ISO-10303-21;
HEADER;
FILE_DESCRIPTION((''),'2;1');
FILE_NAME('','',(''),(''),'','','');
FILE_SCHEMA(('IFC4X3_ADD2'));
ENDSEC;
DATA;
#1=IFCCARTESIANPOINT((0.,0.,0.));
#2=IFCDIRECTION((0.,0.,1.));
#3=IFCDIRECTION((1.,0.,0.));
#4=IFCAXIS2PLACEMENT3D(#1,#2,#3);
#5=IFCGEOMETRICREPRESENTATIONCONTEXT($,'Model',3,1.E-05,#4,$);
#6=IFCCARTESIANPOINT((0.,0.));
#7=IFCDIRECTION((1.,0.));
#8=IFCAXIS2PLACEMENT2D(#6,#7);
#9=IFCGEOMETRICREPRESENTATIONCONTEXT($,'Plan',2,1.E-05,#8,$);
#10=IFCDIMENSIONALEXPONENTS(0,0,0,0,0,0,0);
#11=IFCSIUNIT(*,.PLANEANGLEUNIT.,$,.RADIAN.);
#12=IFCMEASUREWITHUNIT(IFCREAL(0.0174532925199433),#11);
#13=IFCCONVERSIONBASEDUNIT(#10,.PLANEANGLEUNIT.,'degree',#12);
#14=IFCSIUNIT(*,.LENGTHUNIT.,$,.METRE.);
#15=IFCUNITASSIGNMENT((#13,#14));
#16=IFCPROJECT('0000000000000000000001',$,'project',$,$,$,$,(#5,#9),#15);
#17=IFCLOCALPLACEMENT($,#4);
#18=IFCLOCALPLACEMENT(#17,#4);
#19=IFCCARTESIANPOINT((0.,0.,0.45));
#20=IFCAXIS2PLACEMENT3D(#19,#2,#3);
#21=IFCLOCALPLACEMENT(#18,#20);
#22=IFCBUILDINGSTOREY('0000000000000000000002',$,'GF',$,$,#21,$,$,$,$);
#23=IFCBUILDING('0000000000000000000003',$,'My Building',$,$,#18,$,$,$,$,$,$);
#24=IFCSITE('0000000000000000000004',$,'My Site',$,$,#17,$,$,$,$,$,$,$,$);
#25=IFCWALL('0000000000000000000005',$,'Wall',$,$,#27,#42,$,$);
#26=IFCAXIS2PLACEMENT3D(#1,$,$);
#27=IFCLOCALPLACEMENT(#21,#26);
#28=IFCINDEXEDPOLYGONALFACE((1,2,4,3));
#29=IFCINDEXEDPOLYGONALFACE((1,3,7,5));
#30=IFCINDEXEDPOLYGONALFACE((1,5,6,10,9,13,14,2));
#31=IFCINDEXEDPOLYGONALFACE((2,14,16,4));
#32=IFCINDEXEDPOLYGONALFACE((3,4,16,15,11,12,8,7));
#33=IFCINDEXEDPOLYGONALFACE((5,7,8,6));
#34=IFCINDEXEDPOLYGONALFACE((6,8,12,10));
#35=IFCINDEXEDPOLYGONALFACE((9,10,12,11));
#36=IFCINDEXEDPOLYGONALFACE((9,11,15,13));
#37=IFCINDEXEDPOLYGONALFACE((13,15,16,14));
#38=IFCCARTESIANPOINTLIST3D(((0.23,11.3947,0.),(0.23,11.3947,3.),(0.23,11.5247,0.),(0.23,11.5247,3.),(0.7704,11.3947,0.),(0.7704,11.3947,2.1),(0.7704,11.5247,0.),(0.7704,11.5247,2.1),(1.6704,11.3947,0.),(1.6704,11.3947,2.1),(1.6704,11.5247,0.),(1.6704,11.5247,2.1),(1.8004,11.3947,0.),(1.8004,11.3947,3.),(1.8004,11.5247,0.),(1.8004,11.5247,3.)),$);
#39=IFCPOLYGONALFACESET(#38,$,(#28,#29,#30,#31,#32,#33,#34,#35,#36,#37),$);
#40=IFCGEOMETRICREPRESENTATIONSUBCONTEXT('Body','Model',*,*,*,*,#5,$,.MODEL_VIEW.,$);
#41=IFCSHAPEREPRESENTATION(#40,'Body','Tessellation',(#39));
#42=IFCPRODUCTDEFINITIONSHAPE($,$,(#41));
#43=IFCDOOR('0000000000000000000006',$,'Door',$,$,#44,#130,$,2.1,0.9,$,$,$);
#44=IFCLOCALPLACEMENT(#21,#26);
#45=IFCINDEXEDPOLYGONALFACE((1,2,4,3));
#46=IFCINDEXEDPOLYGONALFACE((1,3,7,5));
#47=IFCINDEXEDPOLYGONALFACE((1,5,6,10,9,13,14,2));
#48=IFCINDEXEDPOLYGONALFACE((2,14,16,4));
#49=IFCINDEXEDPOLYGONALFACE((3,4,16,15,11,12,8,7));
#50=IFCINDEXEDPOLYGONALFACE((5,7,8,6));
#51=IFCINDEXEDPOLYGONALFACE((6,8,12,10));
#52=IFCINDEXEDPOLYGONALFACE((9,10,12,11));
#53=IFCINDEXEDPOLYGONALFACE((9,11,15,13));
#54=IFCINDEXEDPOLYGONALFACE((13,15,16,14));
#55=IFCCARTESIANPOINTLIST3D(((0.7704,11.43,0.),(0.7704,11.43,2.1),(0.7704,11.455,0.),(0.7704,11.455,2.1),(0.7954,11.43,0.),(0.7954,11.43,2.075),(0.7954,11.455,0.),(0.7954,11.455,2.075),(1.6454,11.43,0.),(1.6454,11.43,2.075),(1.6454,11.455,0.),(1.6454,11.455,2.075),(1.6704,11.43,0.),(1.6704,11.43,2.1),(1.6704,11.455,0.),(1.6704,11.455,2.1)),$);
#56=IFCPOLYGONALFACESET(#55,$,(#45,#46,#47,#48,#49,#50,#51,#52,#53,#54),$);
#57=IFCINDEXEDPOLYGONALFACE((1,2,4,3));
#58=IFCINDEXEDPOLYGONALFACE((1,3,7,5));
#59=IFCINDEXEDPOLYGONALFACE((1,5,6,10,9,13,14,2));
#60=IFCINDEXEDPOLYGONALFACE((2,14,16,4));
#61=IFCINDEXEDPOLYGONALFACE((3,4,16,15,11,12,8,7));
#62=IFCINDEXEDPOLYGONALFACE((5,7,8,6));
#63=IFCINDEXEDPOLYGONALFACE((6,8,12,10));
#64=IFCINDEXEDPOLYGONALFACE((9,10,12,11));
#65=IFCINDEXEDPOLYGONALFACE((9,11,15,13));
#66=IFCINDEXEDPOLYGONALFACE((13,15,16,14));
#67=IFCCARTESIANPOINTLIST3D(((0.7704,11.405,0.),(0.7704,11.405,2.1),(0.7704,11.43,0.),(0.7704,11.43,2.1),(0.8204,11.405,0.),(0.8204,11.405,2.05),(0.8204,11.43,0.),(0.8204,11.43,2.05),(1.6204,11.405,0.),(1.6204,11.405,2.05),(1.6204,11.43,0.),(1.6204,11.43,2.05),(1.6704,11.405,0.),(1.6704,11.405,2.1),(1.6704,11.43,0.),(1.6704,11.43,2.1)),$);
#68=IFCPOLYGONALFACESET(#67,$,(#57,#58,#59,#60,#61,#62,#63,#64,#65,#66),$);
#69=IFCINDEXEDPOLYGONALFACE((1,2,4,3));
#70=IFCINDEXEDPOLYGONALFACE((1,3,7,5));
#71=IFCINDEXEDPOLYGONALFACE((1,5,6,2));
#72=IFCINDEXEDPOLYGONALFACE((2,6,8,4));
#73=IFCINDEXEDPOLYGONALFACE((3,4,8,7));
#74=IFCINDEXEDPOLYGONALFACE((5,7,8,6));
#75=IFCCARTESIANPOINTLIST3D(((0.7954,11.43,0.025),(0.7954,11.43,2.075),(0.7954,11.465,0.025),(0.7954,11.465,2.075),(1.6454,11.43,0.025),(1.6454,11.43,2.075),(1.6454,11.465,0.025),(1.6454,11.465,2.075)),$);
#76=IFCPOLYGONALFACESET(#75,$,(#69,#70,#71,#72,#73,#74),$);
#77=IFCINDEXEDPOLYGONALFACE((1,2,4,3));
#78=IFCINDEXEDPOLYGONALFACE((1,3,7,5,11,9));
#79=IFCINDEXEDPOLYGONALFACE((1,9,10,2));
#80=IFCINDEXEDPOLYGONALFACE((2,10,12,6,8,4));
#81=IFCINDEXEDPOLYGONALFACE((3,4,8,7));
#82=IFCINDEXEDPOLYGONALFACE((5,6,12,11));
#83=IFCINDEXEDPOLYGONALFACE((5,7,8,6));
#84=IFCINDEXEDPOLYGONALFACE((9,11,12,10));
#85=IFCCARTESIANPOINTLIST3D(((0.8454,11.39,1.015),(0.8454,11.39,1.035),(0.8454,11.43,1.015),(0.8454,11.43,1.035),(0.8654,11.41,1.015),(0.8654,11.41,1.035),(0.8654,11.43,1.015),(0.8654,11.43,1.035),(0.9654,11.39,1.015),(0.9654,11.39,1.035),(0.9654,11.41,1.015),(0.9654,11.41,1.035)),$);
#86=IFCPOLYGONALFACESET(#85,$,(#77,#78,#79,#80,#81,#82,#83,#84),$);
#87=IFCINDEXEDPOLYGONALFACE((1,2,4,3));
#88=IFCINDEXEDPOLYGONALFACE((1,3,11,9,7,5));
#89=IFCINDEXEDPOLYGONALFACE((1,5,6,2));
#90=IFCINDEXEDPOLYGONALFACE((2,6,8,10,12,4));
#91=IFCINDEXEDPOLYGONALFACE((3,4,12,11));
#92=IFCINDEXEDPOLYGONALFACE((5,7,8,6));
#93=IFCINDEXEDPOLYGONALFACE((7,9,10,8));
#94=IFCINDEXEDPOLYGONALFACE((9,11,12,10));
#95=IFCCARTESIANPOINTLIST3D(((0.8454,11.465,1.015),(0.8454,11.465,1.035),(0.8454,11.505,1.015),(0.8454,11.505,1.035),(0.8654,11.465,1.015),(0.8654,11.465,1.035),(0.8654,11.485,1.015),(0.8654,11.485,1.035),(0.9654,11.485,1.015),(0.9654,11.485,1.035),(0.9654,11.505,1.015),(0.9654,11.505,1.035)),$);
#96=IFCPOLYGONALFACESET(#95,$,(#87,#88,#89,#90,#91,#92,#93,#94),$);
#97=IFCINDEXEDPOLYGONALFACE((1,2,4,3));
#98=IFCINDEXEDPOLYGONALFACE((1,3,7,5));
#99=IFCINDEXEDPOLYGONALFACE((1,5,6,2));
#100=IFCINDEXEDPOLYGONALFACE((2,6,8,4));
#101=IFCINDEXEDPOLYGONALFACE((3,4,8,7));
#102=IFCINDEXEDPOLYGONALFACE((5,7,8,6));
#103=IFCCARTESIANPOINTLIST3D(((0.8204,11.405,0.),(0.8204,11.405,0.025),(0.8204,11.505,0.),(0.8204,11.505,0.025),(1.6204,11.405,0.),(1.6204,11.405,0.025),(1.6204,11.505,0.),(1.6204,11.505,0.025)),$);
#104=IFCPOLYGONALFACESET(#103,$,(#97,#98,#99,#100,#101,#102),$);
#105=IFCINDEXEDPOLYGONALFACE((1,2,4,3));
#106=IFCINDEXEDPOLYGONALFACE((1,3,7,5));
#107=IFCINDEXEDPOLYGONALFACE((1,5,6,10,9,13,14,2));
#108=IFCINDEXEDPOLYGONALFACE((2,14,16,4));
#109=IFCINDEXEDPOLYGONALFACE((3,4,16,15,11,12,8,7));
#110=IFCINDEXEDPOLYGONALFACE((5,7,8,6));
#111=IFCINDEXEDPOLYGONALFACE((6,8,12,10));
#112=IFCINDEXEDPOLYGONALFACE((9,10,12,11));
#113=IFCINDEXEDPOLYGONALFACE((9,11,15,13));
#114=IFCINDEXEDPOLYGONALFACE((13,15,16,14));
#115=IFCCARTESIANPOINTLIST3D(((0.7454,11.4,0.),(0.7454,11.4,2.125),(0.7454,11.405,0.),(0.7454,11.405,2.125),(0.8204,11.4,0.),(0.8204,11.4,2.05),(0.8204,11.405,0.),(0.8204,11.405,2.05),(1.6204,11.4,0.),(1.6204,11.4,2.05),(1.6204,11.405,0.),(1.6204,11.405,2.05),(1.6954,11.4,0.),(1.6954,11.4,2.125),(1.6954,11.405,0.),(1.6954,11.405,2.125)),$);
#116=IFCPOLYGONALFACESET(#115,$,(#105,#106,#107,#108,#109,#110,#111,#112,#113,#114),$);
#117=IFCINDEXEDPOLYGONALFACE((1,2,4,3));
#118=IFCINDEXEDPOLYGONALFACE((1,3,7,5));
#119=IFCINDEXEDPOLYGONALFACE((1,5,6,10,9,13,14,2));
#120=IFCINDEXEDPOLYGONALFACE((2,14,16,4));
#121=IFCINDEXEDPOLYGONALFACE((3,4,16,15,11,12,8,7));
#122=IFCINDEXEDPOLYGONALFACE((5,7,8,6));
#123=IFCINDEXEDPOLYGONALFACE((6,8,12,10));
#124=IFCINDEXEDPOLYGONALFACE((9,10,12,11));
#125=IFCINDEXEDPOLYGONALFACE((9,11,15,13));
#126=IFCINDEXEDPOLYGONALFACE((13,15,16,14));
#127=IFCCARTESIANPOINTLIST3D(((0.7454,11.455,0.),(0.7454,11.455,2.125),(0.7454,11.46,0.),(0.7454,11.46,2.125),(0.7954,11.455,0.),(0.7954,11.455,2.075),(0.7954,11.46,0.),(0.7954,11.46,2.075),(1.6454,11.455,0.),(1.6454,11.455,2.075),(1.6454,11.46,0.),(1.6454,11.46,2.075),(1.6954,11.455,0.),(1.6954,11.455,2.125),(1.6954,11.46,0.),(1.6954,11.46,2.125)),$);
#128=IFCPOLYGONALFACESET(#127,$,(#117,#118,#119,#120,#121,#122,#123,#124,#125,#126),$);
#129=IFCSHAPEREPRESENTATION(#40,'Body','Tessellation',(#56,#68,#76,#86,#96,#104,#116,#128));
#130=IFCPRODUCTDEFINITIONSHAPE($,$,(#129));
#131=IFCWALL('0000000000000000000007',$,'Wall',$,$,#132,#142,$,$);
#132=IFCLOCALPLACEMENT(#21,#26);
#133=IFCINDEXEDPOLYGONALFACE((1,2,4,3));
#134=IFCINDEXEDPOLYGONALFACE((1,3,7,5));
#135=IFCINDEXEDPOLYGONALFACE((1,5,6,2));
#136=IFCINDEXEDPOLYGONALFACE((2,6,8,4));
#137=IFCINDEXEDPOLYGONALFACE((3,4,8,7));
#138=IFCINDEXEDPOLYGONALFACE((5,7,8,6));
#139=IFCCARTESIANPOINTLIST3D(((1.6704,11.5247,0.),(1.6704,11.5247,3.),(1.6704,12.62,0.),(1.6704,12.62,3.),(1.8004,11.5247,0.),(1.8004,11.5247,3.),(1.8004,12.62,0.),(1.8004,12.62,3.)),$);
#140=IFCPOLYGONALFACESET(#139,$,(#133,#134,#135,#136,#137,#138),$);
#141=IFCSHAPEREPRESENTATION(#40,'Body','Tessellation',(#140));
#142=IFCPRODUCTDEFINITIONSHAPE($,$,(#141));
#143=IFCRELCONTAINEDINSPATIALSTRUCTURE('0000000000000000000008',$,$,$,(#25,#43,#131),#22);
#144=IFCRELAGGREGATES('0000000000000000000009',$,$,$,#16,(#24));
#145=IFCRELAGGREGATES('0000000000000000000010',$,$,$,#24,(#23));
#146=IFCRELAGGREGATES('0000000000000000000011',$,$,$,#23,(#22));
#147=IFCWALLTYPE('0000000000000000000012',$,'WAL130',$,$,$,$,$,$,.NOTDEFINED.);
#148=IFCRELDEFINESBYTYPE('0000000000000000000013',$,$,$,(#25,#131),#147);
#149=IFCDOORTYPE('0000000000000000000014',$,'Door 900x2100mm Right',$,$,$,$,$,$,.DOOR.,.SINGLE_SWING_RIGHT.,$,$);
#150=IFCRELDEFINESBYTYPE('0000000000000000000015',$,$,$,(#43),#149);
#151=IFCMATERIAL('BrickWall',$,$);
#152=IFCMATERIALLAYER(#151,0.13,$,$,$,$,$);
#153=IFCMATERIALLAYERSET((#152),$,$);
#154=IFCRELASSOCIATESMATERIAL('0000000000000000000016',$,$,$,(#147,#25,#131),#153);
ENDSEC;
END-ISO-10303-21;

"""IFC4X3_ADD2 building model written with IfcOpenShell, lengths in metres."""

from ifc_helpers import new_model, entity, si_unit, converted_unit, frame, origin_with_axes, origin_2d_with_axis, place, context, subcontext, project, spatial, line, indexed_curve, outline, extrude, shape, source, transform, mapped, material, layer, layer_set, layer_usage, type_object, type_shapes, element, fill, save


model = new_model("IFC4X3_ADD2")

# Units and contexts
model_context = context("Model", 3, precision=1e-05, world=origin_with_axes())
plan_context = context("Plan", 2, precision=1e-05, world=origin_2d_with_axis())
body_context_1 = subcontext(model_context, "Body", "Model", "MODEL_VIEW")
body_context_2 = subcontext(plan_context, "Body", "Plan", "PLAN_VIEW")
ifc_project = project(units=[converted_unit("PLANEANGLEUNIT", "degree", entity("IfcReal", 0.0174532925199433), si_unit("PLANEANGLEUNIT", "RADIAN"), dimensions=[0, 0, 0, 0, 0, 0, 0]), si_unit("LENGTHUNIT", "METRE")], contexts=[model_context, plan_context])

# Site, building, storey
site_placement = place(None, origin_with_axes())
site = spatial("IfcSite", under=ifc_project, at=site_placement, Name="My Site")
building_placement = place(site_placement, origin_with_axes())
building = spatial("IfcBuilding", under=site, at=building_placement, Name="My Building")
storey_placement = place(building_placement, frame((0.0, 0.0, 0.45), z_axis=(0.0, 0.0, 1.0), x_axis=(1.0, 0.0, 0.0)))
storey = spatial("IfcBuildingStorey", under=building, at=storey_placement, Name="GF")

# Shared definitions
ifc_material = material(Name="BrickWall")

# Wall, opening, door
ifc_layer_1 = layer(ifc_material, 0.13)
ifc_layer_set_1 = layer_set([ifc_layer_1])
wall_type_1 = type_object("IfcWallType", Name="WAL130", PredefinedType="NOTDEFINED", material=ifc_layer_set_1)
ifc_layer_usage_1 = layer_usage(ifc_layer_set_1, "AXIS2", "POSITIVE", 0.0)
wall_1_placement = place(storey_placement, frame((0.23, 11.3947, 0.0), z_axis=(0.0, 0.0, 1.0), x_axis=(1.0, 0.0, 0.0)))
wall_1 = element("IfcWall", 1, at=wall_1_placement, inside=storey, type_object=wall_type_1, material=ifc_layer_usage_1, Name="Wall", context=body_context_1, shape_type="SweptSolid", body=[
    extrude(outline(indexed_curve([(0.0, 0.0), (0.0, 0.13), (1.5704, 0.13), (1.5704, 0.0), (0.0, 0.0)], self_intersect=False)), origin_with_axes(), (0.0, 0.0, 1.0), 3.0),
])
shared_shape_1 = source(origin_with_axes(), body_context_1, "Body", "SweptSolid", [
    extrude(outline(indexed_curve([(0.0, 0.0), (0.9, 0.0), (0.9, 2.1), (0.0, 2.1)], segments=[line(1, 2, 3, 4, 1)])), frame((0.0, -0.6, 0.0), z_axis=(0.0, -1.0, 0.0), x_axis=(1.0, 0.0, 0.0)), (0.0, 0.0, -1.0), 1.2),
])
opening_1_placement = place(wall_1_placement, frame((0.5404, 0.0103, 0.0), z_axis=(0.0, 0.0, 1.0), x_axis=(1.0, 0.0, 0.0)))
opening_1 = element("IfcOpeningElement", 2, at=opening_1_placement, cuts=wall_1, PredefinedType="OPENING", context=body_context_1, shape_type="MappedRepresentation", body=[
    mapped(shared_shape_1, transform((0.0, 0.0, 0.0), x_axis=(1.0, 0.0, 0.0), y_axis=(0.0, 1.0, 0.0), z_axis=(0.0, 0.0, 1.0), scale=1.0)),
])
door_type_1 = type_object("IfcDoorType", Name="Door 900x2100mm Right", OperationType="SINGLE_SWING_RIGHT", PredefinedType="DOOR")
shared_shape_2 = source(origin_with_axes(), body_context_1, "Body", "SweptSolid", [
    extrude(outline(indexed_curve([(0.0, 0.0), (0.0, 2.1), (0.9, 2.1), (0.9, 0.0), (0.875, 0.0), (0.875, 2.075), (0.025, 2.075), (0.025, 0.0)], segments=[line(1, 2, 3, 4, 5, 6, 7, 8, 1)])), frame((0.0, 0.025, 0.0), z_axis=(0.0, -1.0, 0.0), x_axis=(1.0, 0.0, 0.0)), (0.0, 0.0, -1.0), 0.025),
    extrude(outline(indexed_curve([(0.0, 0.0), (0.0, 2.1), (0.9, 2.1), (0.9, 0.0), (0.85, 0.0), (0.85, 2.05), (0.05, 2.05), (0.05, 0.0)], segments=[line(1, 2, 3, 4, 5, 6, 7, 8, 1)])), frame((0.0, 0.0, 0.0), z_axis=(0.0, -1.0, 0.0), x_axis=(1.0, 0.0, 0.0)), (0.0, 0.0, -1.0), 0.025),
    extrude(outline(indexed_curve([(0.0, 0.0), (0.85, 0.0), (0.85, 0.035), (0.0, 0.035)], segments=[line(1, 2, 3, 4, 1)])), frame((0.025, 0.025, 0.025), z_axis=(0.0, 0.0, 1.0), x_axis=(1.0, 0.0, 0.0)), (0.0, 0.0, 1.0), 2.05),
    extrude(outline(indexed_curve([(0.0, 0.0), (0.0, -0.04), (0.12, -0.04), (0.12, -0.02), (0.02, -0.02), (0.02, 0.0)], segments=[line(1, 2, 3, 4, 5, 6, 1)])), frame((0.075, 0.025, 1.015), z_axis=(0.0, 0.0, 1.0), x_axis=(1.0, 0.0, 0.0)), (0.0, 0.0, 1.0), 0.02),
    extrude(outline(indexed_curve([(0.0, 0.0), (0.0, 0.04), (0.12, 0.04), (0.12, 0.02), (0.02, 0.02), (0.02, 0.0)], segments=[line(1, 2, 3, 4, 5, 6, 1)])), frame((0.075, 0.06, 1.015), z_axis=(0.0, 0.0, 1.0), x_axis=(1.0, 0.0, 0.0)), (0.0, 0.0, 1.0), 0.02),
    extrude(outline(indexed_curve([(0.0, 0.0), (0.8, 0.0), (0.8, 0.1), (0.0, 0.1)], segments=[line(1, 2, 3, 4, 1)])), frame((0.05, 0.0, 0.0), z_axis=(0.0, 0.0, 1.0), x_axis=(1.0, 0.0, 0.0)), (0.0, 0.0, 1.0), 0.025),
    extrude(outline(indexed_curve([(0.0, 0.0), (0.0, 2.125), (0.95, 2.125), (0.95, 0.0), (0.875, 0.0), (0.875, 2.05), (0.075, 2.05), (0.075, 0.0)], segments=[line(1, 2, 3, 4, 5, 6, 7, 8, 1)])), frame((-0.025, -0.005, 0.0), z_axis=(0.0, -1.0, 0.0), x_axis=(1.0, 0.0, 0.0)), (0.0, 0.0, -1.0), 0.005),
    extrude(outline(indexed_curve([(0.0, 0.0), (0.0, 2.125), (0.95, 2.125), (0.95, 0.0), (0.9, 0.0), (0.9, 2.075), (0.05, 2.075), (0.05, 0.0)], segments=[line(1, 2, 3, 4, 5, 6, 7, 8, 1)])), frame((-0.025, 0.05, 0.0), z_axis=(0.0, -1.0, 0.0), x_axis=(1.0, 0.0, 0.0)), (0.0, 0.0, -1.0), 0.005),
])
shared_shape_3 = source(origin_with_axes(), body_context_2, "Body", "Curve2D", [
    entity("IfcIndexedPolyCurve", entity("IfcCartesianPointList2D", [[0.0, 0.0], [0.0, 0.05], [0.025, 0.05], [0.025, 0.025], [0.05, 0.025], [0.05, 0.0]]), [entity("IfcLineIndex", [1, 2, 3, 4, 5, 6, 1])]),
    entity("IfcIndexedPolyCurve", entity("IfcCartesianPointList2D", [[0.9, 0.0], [0.9, 0.05], [0.875, 0.05], [0.875, 0.025], [0.85, 0.025], [0.85, 0.0]]), [entity("IfcLineIndex", [1, 2, 3, 4, 5, 6, 1])]),
    entity("IfcTrimmedCurve", entity("IfcEllipse", entity("IfcAxis2Placement2D", entity("IfcCartesianPoint", [0.84, 0.05]), entity("IfcDirection", [1.0, 0.0])), 0.815, 0.85), [entity("IfcCartesianPoint", [0.84, 0.9])], [entity("IfcCartesianPoint", [0.025, 0.05])], True, "CARTESIAN"),
    entity("IfcIndexedPolyCurve", entity("IfcCartesianPointList2D", [[0.875, 0.05], [0.84, 0.05], [0.84, 0.9], [0.875, 0.9]]), [entity("IfcLineIndex", [1, 2, 3, 4, 1])]),
])
type_shapes(door_type_1, [shared_shape_2, shared_shape_3])
door_1_placement = place(opening_1_placement, origin_with_axes())
door_1 = element("IfcDoor", 3, at=door_1_placement, inside=storey, type_object=door_type_1, Name="Door", OverallHeight=2.1, OverallWidth=0.9, shapes=[
    shape(body_context_1, "Body", "MappedRepresentation", [mapped(shared_shape_2, transform((0.0, 0.0, 0.0), x_axis=(1.0, 0.0, 0.0), y_axis=(0.0, 1.0, 0.0), z_axis=(0.0, 0.0, 1.0), scale=1.0))]),
    shape(body_context_2, "Body", "MappedRepresentation", [mapped(shared_shape_3, transform((0.0, 0.0, 0.0), x_axis=(1.0, 0.0, 0.0), y_axis=(0.0, 1.0, 0.0), z_axis=(0.0, 0.0, 1.0), scale=1.0))]),
])
fill(opening_1, door_1)

# Wall
ifc_layer_usage_2 = layer_usage(ifc_layer_set_1, "AXIS2", "POSITIVE", 0.0)
wall_2_placement = place(storey_placement, frame((1.8004, 11.5247, 0.0), z_axis=(0.0, 0.0, 1.0), x_axis=(0.0, 1.0, 0.0)))
element("IfcWall", 4, at=wall_2_placement, inside=storey, type_object=wall_type_1, material=ifc_layer_usage_2, Name="Wall", context=body_context_1, shape_type="SweptSolid", body=[
    extrude(outline(indexed_curve([(0.0, 0.0), (0.0, 0.13), (1.0953, 0.13), (1.0953, 0.0), (0.0, 0.0)], self_intersect=False)), origin_with_axes(), (0.0, 0.0, 1.0), 3.0),
])

save(model, "model.ifc")
